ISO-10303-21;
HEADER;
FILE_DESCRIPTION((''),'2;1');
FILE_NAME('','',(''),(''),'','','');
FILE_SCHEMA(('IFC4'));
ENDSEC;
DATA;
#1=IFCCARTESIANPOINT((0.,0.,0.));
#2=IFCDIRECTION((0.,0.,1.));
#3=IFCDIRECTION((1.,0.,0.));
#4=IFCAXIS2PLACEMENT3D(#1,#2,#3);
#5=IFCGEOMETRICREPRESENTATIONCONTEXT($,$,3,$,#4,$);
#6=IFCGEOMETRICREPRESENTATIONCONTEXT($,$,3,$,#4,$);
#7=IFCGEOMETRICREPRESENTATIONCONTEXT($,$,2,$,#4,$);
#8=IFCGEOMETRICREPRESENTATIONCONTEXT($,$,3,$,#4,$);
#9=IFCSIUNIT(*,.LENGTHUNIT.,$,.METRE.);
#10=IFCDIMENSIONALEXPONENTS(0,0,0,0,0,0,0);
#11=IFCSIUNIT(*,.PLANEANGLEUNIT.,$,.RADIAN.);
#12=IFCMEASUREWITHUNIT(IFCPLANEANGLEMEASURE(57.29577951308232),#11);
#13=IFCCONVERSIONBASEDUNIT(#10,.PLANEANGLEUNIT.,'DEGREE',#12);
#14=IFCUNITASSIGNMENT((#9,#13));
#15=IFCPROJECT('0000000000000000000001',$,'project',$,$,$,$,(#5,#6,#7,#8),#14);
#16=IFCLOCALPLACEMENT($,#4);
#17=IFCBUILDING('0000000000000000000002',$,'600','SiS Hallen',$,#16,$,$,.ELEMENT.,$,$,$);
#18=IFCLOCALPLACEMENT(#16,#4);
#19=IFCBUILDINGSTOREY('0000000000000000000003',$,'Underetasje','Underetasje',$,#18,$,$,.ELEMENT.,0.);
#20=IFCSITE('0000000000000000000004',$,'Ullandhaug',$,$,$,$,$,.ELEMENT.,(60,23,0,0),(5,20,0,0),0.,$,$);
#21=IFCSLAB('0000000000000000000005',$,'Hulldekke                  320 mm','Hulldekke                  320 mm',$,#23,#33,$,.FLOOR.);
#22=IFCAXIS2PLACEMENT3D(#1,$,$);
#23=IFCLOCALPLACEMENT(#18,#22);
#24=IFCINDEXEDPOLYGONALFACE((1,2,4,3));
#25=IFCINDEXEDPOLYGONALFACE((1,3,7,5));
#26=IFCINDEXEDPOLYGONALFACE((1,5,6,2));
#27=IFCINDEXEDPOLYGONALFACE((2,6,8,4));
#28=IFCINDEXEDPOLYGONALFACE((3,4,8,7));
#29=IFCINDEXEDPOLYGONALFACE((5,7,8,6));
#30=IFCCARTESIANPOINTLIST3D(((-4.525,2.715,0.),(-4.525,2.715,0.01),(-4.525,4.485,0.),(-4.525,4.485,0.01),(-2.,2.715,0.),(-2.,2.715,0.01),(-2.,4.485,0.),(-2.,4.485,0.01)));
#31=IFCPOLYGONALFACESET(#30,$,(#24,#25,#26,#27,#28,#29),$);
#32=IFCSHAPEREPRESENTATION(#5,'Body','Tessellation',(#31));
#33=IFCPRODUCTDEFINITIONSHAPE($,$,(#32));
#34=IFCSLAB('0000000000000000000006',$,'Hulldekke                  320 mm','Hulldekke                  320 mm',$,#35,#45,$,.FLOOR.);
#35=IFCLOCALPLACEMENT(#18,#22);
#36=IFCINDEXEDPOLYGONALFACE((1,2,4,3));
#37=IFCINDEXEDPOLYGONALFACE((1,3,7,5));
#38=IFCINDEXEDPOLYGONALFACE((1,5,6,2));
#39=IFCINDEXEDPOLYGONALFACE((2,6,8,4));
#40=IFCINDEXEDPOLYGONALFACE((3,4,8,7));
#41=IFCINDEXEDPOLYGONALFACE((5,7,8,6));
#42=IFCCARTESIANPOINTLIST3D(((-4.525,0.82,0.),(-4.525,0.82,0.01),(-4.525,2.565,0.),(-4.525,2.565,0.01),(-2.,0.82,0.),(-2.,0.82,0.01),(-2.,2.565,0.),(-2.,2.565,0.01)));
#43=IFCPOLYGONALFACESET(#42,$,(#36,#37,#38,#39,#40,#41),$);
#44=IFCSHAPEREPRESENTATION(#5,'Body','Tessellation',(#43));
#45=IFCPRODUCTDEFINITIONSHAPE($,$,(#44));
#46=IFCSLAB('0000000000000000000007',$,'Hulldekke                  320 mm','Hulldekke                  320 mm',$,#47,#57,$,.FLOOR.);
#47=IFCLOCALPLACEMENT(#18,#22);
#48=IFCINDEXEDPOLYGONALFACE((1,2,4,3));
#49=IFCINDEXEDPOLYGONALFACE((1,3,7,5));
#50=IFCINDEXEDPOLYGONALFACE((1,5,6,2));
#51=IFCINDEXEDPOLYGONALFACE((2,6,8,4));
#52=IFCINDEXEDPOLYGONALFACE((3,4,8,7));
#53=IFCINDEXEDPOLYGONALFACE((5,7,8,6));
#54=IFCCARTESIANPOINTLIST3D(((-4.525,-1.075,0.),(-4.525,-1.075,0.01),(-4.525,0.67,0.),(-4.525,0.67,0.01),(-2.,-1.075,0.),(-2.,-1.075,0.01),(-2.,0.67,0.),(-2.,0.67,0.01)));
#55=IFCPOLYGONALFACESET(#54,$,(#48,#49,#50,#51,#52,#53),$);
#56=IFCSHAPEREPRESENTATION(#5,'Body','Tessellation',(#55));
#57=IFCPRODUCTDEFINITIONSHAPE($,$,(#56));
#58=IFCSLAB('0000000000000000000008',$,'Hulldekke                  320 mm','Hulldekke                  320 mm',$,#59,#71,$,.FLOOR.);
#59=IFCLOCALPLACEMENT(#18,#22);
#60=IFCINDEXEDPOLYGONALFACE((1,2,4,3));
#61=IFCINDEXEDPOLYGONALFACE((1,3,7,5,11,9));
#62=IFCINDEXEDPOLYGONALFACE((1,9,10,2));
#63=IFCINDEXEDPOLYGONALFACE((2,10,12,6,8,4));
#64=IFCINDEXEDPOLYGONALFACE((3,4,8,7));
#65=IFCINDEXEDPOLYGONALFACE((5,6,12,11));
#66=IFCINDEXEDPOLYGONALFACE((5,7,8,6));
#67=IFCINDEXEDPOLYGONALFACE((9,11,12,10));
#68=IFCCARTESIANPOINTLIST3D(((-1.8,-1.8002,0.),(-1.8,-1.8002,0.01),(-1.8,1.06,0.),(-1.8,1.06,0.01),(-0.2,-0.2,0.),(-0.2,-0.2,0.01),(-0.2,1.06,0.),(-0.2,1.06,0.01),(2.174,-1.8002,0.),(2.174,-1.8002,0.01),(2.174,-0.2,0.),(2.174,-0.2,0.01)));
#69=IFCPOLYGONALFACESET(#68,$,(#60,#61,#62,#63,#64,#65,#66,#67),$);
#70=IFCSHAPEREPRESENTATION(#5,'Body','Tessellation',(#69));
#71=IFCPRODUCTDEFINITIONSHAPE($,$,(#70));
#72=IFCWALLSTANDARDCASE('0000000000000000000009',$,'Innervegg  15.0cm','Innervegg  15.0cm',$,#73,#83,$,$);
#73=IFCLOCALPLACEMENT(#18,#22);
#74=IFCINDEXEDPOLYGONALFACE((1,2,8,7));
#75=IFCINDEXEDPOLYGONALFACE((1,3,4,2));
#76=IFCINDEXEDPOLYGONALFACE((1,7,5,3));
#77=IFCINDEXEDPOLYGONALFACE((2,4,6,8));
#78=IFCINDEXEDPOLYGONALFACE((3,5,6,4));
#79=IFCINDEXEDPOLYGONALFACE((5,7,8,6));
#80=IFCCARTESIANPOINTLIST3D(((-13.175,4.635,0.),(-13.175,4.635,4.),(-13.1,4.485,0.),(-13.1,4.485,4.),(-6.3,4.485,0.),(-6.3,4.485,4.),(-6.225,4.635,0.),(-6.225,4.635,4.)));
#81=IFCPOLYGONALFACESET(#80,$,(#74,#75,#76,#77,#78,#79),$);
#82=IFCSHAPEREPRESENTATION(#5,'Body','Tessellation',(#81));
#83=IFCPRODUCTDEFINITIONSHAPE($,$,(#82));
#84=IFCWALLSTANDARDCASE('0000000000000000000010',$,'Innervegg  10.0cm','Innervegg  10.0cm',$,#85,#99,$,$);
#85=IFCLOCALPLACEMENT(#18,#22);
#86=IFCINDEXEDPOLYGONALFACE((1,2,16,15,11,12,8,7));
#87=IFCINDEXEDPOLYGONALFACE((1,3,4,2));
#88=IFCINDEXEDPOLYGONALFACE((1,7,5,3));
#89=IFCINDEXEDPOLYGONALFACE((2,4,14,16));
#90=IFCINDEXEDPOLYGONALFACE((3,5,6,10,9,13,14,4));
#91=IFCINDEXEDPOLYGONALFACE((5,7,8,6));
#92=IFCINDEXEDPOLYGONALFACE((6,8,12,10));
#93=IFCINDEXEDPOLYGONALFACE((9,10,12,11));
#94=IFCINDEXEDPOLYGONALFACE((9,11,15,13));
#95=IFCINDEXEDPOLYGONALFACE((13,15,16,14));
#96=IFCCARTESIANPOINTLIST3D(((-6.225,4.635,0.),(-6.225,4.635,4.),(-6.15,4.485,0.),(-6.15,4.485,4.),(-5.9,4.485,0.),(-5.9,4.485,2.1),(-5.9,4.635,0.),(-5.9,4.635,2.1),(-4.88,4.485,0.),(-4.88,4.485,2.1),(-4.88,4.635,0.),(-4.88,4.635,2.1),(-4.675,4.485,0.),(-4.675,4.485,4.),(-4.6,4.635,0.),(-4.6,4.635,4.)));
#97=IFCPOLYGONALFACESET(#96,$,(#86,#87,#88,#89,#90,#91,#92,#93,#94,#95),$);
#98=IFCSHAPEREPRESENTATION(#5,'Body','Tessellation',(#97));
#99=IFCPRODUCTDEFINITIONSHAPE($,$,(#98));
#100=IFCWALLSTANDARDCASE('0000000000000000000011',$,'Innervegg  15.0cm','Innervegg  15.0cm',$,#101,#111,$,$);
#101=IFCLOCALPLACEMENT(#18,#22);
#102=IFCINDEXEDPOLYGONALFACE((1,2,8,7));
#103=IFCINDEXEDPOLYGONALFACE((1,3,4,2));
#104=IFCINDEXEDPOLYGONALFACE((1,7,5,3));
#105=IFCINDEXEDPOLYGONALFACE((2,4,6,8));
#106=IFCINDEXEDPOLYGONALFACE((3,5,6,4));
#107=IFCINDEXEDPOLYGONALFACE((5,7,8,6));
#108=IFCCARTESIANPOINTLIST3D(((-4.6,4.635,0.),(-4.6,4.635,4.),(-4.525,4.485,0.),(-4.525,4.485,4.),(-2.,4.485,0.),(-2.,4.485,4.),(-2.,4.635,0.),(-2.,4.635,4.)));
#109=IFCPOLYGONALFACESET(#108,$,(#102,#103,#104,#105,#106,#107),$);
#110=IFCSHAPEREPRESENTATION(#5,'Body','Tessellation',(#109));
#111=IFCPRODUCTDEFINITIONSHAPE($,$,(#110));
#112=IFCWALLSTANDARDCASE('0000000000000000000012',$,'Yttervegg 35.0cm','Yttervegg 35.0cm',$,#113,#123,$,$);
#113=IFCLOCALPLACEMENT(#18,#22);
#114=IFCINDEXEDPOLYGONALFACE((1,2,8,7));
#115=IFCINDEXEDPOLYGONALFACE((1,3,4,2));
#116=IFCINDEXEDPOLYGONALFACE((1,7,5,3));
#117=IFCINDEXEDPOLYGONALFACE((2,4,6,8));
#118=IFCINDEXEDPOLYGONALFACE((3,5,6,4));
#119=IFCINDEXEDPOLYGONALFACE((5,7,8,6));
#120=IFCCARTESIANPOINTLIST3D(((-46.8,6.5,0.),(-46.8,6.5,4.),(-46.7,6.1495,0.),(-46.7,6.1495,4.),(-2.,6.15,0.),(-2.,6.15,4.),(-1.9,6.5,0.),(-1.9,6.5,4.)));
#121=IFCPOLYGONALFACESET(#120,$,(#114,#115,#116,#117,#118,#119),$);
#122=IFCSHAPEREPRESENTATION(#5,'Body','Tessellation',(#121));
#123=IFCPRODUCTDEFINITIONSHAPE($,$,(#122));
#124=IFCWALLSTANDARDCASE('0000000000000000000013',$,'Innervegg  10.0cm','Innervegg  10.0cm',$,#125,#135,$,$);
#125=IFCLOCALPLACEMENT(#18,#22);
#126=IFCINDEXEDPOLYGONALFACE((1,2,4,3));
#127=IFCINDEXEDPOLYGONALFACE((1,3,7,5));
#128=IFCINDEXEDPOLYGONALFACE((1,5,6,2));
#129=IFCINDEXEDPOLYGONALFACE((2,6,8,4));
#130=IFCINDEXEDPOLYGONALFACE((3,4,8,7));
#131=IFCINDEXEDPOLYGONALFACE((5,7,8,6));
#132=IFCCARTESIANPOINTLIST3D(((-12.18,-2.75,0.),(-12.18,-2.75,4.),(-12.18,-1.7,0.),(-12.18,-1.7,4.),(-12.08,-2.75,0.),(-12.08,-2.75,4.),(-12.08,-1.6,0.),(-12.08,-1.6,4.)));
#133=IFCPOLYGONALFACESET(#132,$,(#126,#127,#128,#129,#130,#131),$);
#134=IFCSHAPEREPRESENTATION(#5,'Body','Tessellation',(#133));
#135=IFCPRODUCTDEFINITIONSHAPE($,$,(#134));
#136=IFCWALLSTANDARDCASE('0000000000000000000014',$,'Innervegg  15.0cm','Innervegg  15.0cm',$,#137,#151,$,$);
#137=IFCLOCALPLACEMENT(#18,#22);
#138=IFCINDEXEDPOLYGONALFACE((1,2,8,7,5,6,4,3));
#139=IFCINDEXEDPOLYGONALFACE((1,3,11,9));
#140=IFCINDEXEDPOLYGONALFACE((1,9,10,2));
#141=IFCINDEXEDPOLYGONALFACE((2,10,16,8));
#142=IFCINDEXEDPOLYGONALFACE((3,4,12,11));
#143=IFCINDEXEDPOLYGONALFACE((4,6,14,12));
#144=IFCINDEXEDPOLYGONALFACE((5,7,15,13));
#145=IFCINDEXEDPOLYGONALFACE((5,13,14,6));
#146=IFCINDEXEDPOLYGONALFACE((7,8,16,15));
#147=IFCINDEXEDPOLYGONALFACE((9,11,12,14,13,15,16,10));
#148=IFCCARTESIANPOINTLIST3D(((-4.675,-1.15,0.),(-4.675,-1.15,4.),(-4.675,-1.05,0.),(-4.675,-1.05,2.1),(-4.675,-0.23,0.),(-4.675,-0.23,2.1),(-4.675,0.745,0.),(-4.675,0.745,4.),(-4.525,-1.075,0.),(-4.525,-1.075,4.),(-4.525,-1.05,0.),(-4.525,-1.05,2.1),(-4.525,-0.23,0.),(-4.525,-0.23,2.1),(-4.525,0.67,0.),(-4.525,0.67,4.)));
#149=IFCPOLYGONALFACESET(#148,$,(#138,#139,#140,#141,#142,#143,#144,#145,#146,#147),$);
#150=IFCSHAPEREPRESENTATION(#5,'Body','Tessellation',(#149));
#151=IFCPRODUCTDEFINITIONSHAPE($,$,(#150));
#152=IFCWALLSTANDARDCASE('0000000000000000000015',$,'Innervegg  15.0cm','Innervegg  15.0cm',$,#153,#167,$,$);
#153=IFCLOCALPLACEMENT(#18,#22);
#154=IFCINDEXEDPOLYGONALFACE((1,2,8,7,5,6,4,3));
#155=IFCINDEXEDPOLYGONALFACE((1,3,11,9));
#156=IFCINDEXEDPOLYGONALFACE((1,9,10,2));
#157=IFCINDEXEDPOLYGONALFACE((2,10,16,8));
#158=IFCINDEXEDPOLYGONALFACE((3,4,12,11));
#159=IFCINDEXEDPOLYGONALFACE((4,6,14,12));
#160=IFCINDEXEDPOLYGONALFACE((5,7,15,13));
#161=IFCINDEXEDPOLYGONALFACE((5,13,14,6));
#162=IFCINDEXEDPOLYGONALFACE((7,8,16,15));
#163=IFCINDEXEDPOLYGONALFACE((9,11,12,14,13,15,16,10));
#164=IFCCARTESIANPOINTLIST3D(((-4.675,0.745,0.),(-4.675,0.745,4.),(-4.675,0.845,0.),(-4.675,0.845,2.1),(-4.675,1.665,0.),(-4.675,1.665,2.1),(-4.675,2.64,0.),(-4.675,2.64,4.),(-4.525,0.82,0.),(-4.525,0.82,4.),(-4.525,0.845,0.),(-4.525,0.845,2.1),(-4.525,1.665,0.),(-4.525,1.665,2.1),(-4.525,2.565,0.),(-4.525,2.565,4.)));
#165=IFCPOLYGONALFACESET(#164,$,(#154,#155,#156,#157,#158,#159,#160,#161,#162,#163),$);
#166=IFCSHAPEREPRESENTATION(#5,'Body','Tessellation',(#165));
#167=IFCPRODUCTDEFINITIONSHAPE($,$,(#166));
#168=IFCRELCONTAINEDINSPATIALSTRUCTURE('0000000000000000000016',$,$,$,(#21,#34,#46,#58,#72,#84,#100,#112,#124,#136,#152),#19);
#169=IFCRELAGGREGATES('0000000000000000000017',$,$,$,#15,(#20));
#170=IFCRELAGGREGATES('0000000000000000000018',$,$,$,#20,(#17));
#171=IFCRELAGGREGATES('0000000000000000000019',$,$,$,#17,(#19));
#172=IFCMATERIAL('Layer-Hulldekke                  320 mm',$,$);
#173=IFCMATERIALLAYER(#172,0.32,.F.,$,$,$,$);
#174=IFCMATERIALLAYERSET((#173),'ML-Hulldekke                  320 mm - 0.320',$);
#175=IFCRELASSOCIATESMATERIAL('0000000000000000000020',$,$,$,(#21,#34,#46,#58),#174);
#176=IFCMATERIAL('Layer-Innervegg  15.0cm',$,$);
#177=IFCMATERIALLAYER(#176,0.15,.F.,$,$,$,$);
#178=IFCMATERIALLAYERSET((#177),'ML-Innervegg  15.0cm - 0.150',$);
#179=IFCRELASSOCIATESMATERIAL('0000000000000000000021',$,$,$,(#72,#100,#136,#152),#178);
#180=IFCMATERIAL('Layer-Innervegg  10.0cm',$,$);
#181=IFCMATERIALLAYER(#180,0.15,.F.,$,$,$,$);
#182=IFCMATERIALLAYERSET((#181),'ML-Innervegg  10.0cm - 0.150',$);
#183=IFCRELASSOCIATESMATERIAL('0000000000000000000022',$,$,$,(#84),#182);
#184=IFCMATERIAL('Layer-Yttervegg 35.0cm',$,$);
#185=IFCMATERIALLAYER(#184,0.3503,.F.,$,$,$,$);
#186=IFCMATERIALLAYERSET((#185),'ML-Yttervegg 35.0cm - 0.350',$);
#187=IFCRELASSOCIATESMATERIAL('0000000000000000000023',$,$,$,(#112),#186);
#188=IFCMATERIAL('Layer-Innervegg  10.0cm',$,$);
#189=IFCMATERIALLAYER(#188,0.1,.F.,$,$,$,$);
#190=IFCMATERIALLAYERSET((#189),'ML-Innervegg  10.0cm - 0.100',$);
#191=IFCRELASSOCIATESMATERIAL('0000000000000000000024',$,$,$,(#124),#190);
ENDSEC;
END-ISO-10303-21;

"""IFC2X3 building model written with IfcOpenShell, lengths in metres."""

from ifc_helpers import new_model, entity, si_unit, converted_unit, frame, origin_with_axes, place, context, project, spatial, polyline, outline, extrude, material, layer, layer_set, layer_usage, element, save


model = new_model("IFC2X3")

# Units and contexts
context_of_model_1 = context(None, 3, world=origin_with_axes())
context_of_model_2 = context(None, 3, world=origin_with_axes())
context_of_model_3 = context(None, 2, world=origin_with_axes())
context_of_model_4 = context(None, 3, world=origin_with_axes())
ifc_project = project(units=[si_unit("LENGTHUNIT", "METRE"), converted_unit("PLANEANGLEUNIT", "DEGREE", entity("IfcPlaneAngleMeasure", 57.29577951308232), si_unit("PLANEANGLEUNIT", "RADIAN"), dimensions=[0, 0, 0, 0, 0, 0, 0])], contexts=[context_of_model_1, context_of_model_2, context_of_model_3, context_of_model_4])

# Site, building, storey
site = spatial("IfcSite", under=ifc_project, Name="Ullandhaug", CompositionType="ELEMENT", RefLatitude=(60, 23, 0, 0), RefLongitude=(5, 20, 0, 0), RefElevation=0.0)
building_placement = place(None, origin_with_axes())
building = spatial("IfcBuilding", under=site, at=building_placement, Name="600", Description="SiS Hallen", CompositionType="ELEMENT")
storey_placement = place(building_placement, origin_with_axes())
storey = spatial("IfcBuildingStorey", under=building, at=storey_placement, Name="Underetasje", Description="Underetasje", CompositionType="ELEMENT", Elevation=0.0)

# Slabs
ifc_material_1 = material(Name="Layer-Hulldekke                  320 mm")
ifc_layer_1 = layer(ifc_material_1, 0.32, ventilated=False)
ifc_layer_set_1 = layer_set([ifc_layer_1], Name="ML-Hulldekke                  320 mm - 0.320")
ifc_layer_usage_1 = layer_usage(ifc_layer_set_1, "AXIS2", "POSITIVE", 0.0)
slab_1_placement = place(storey_placement, frame((-4.525, 2.715, 0.0), z_axis=(0.0, 0.0, 1.0), x_axis=(1.0, 0.0, 0.0)))
element("IfcSlab", 1, at=slab_1_placement, inside=storey, material=ifc_layer_usage_1, Name="Hulldekke                  320 mm", Description="Hulldekke                  320 mm", PredefinedType="FLOOR", context=context_of_model_1, shape_type="SweptSolid", body=[
    extrude(outline(polyline([(0.0, 0.0), (2.525, 0.0), (2.525, 1.77), (0.0, 1.77), (0.0, 0.0)])), origin_with_axes(), (0.0, 0.0, 1.0), 0.01),
])
slab_2_placement = place(storey_placement, frame((-4.525, 0.82, 0.0), z_axis=(0.0, 0.0, 1.0), x_axis=(1.0, 0.0, 0.0)))
element("IfcSlab", 2, at=slab_2_placement, inside=storey, material=ifc_layer_usage_1, Name="Hulldekke                  320 mm", Description="Hulldekke                  320 mm", PredefinedType="FLOOR", context=context_of_model_1, shape_type="SweptSolid", body=[
    extrude(outline(polyline([(0.0, 0.0), (2.525, 0.0), (2.525, 1.745), (0.0, 1.745), (0.0, 0.0)])), origin_with_axes(), (0.0, 0.0, 1.0), 0.01),
])
slab_3_placement = place(storey_placement, frame((-4.525, -1.075, 0.0), z_axis=(0.0, 0.0, 1.0), x_axis=(1.0, 0.0, 0.0)))
element("IfcSlab", 3, at=slab_3_placement, inside=storey, material=ifc_layer_usage_1, Name="Hulldekke                  320 mm", Description="Hulldekke                  320 mm", PredefinedType="FLOOR", context=context_of_model_1, shape_type="SweptSolid", body=[
    extrude(outline(polyline([(0.0, 0.0), (2.525, 0.0), (2.525, 1.745), (0.0, 1.745), (0.0, 0.0)])), origin_with_axes(), (0.0, 0.0, 1.0), 0.01),
])
slab_4_placement = place(storey_placement, frame((-1.8, -1.8002, 0.0), z_axis=(0.0, 0.0, 1.0), x_axis=(1.0, 0.0, 0.0)))
element("IfcSlab", 4, at=slab_4_placement, inside=storey, material=ifc_layer_usage_1, Name="Hulldekke                  320 mm", Description="Hulldekke                  320 mm", PredefinedType="FLOOR", context=context_of_model_1, shape_type="SweptSolid", body=[
    extrude(outline(polyline([(0.0, 0.0), (3.974, 0.0), (3.974, 1.6002), (1.6, 1.6002), (1.6, 2.8602), (0.0, 2.8602), (0.0, 0.0)])), origin_with_axes(), (0.0, 0.0, 1.0), 0.01),
])

# Wall
ifc_material_2 = material(Name="Layer-Innervegg  15.0cm")
ifc_layer_2 = layer(ifc_material_2, 0.15, ventilated=False)
ifc_layer_set_2 = layer_set([ifc_layer_2], Name="ML-Innervegg  15.0cm - 0.150")
ifc_layer_usage_2 = layer_usage(ifc_layer_set_2, "AXIS2", "POSITIVE", 0.0)
wall_1_placement = place(storey_placement, frame((-13.1, 4.485, 0.0), z_axis=(0.0, 0.0, 1.0), x_axis=(1.0, 0.0, 0.0)))
element("IfcWallStandardCase", 5, at=wall_1_placement, inside=storey, material=ifc_layer_usage_2, Name="Innervegg  15.0cm", Description="Innervegg  15.0cm", context=context_of_model_1, shape_type="SweptSolid", body=[
    extrude(outline(polyline([(0.0, 0.0), (6.8, 0.0), (6.875, 0.15), (-0.075, 0.15), (0.0, 0.0)])), origin_with_axes(), (0.0, 0.0, 1.0), 4.0),
])

# Wall, opening
ifc_material_3 = material(Name="Layer-Innervegg  10.0cm")
ifc_layer_3 = layer(ifc_material_3, 0.15, ventilated=False)
ifc_layer_set_3 = layer_set([ifc_layer_3], Name="ML-Innervegg  10.0cm - 0.150")
ifc_layer_usage_3 = layer_usage(ifc_layer_set_3, "AXIS2", "POSITIVE", 0.0)
wall_2_placement = place(storey_placement, frame((-6.15, 4.485, 0.0), z_axis=(0.0, 0.0, 1.0), x_axis=(1.0, 0.0, 0.0)))
wall_2 = element("IfcWallStandardCase", 6, at=wall_2_placement, inside=storey, material=ifc_layer_usage_3, Name="Innervegg  10.0cm", Description="Innervegg  10.0cm", context=context_of_model_1, shape_type="SweptSolid", body=[
    extrude(outline(polyline([(0.0, 0.0), (1.475, 0.0), (1.55, 0.15), (-0.075, 0.15), (0.0, 0.0)])), origin_with_axes(), (0.0, 0.0, 1.0), 4.0),
])
opening_1_placement = place(wall_2_placement, frame((0.25, 0.15, 0.0), z_axis=(0.0, 0.0, 1.0), x_axis=(1.0, 0.0, 0.0)))
element("IfcOpeningElement", 7, at=opening_1_placement, cuts=wall_2, context=context_of_model_1, shape_type="SweptSolid", body=[
    extrude(outline(polyline([(0.0, 0.0), (2.1, 0.0), (2.1, 1.02), (0.0, 1.02), (0.0, 0.0)])), frame((0.0, 0.0, 0.0), z_axis=(0.0, 1.0, 0.0), x_axis=(0.0, 0.0, 1.0)), (0.0, 0.0, -1.0), 0.15),
])

# Walls
wall_3_placement = place(storey_placement, frame((-4.525, 4.485, 0.0), z_axis=(0.0, 0.0, 1.0), x_axis=(1.0, 0.0, 0.0)))
element("IfcWallStandardCase", 8, at=wall_3_placement, inside=storey, material=ifc_layer_usage_2, Name="Innervegg  15.0cm", Description="Innervegg  15.0cm", context=context_of_model_1, shape_type="SweptSolid", body=[
    extrude(outline(polyline([(0.0, 0.0), (2.525, 0.0), (2.525, 0.15), (-0.075, 0.15), (0.0, 0.0)])), origin_with_axes(), (0.0, 0.0, 1.0), 4.0),
])
ifc_material_4 = material(Name="Layer-Yttervegg 35.0cm")
ifc_layer_4 = layer(ifc_material_4, 0.3503, ventilated=False)
ifc_layer_set_4 = layer_set([ifc_layer_4], Name="ML-Yttervegg 35.0cm - 0.350")
ifc_layer_usage_4 = layer_usage(ifc_layer_set_4, "AXIS2", "POSITIVE", 0.0)
wall_4_placement = place(storey_placement, frame((-1.9, 6.5, 0.0), z_axis=(0.0, 0.0, 1.0), x_axis=(-1.0, 0.0, 0.0)))
element("IfcWallStandardCase", 9, at=wall_4_placement, inside=storey, material=ifc_layer_usage_4, Name="Yttervegg 35.0cm", Description="Yttervegg 35.0cm", context=context_of_model_1, shape_type="SweptSolid", body=[
    extrude(outline(polyline([(0.0, 0.0), (44.9, 0.0), (44.8, 0.3505), (0.1, 0.35), (0.0, 0.0)])), frame((0.0, 0.0, 0.0), z_axis=(0.0, 0.0, 1.0), x_axis=(1.0, 0.0, 0.0)), (0.0, 0.0, 1.0), 4.0),
])
ifc_material_5 = material(Name="Layer-Innervegg  10.0cm")
ifc_layer_5 = layer(ifc_material_5, 0.1, ventilated=False)
ifc_layer_set_5 = layer_set([ifc_layer_5], Name="ML-Innervegg  10.0cm - 0.100")
ifc_layer_usage_5 = layer_usage(ifc_layer_set_5, "AXIS2", "POSITIVE", 0.0)
wall_5_placement = place(storey_placement, frame((-12.18, -1.7, 0.0), z_axis=(0.0, 0.0, 1.0), x_axis=(0.0, -1.0, 0.0)))
element("IfcWallStandardCase", 10, at=wall_5_placement, inside=storey, material=ifc_layer_usage_5, Name="Innervegg  10.0cm", Description="Innervegg  10.0cm", context=context_of_model_1, shape_type="SweptSolid", body=[
    extrude(outline(polyline([(0.0, 0.0), (1.05, 0.0), (1.05, 0.1), (-0.1, 0.1), (0.0, 0.0)])), frame((0.0, 0.0, 0.0), z_axis=(0.0, 0.0, 1.0), x_axis=(1.0, 0.0, 0.0)), (0.0, 0.0, 1.0), 4.0),
])

# Walls, openings
wall_6_placement = place(storey_placement, frame((-4.525, -1.075, 0.0), z_axis=(0.0, 0.0, 1.0), x_axis=(0.0, 1.0, 0.0)))
wall_6 = element("IfcWallStandardCase", 11, at=wall_6_placement, inside=storey, material=ifc_layer_usage_2, Name="Innervegg  15.0cm", Description="Innervegg  15.0cm", context=context_of_model_1, shape_type="SweptSolid", body=[
    extrude(outline(polyline([(0.0, 0.0), (1.745, 0.0), (1.82, 0.15), (-0.075, 0.15), (0.0, 0.0)])), frame((0.0, 0.0, 0.0), z_axis=(0.0, 0.0, 1.0), x_axis=(1.0, 0.0, 0.0)), (0.0, 0.0, 1.0), 4.0),
])
opening_2_placement = place(wall_6_placement, frame((0.025, 0.15, 0.0), z_axis=(0.0, 0.0, 1.0), x_axis=(1.0, 0.0, 0.0)))
element("IfcOpeningElement", 12, at=opening_2_placement, cuts=wall_6, context=context_of_model_1, shape_type="SweptSolid", body=[
    extrude(outline(polyline([(0.0, 0.0), (2.1, 0.0), (2.1, 0.82), (0.0, 0.82), (0.0, 0.0)])), frame((0.0, 0.0, 0.0), z_axis=(0.0, 1.0, 0.0), x_axis=(0.0, 0.0, 1.0)), (0.0, 0.0, -1.0), 0.15),
])
wall_7_placement = place(storey_placement, frame((-4.525, 0.82, 0.0), z_axis=(0.0, 0.0, 1.0), x_axis=(0.0, 1.0, 0.0)))
wall_7 = element("IfcWallStandardCase", 13, at=wall_7_placement, inside=storey, material=ifc_layer_usage_2, Name="Innervegg  15.0cm", Description="Innervegg  15.0cm", context=context_of_model_1, shape_type="SweptSolid", body=[
    extrude(outline(polyline([(0.0, 0.0), (1.745, 0.0), (1.82, 0.15), (-0.075, 0.15), (0.0, 0.0)])), frame((0.0, 0.0, 0.0), z_axis=(0.0, 0.0, 1.0), x_axis=(1.0, 0.0, 0.0)), (0.0, 0.0, 1.0), 4.0),
])
opening_3_placement = place(wall_7_placement, frame((0.025, 0.15, 0.0), z_axis=(0.0, 0.0, 1.0), x_axis=(1.0, 0.0, 0.0)))
element("IfcOpeningElement", 14, at=opening_3_placement, cuts=wall_7, context=context_of_model_1, shape_type="SweptSolid", body=[
    extrude(outline(polyline([(0.0, 0.0), (2.1, 0.0), (2.1, 0.82), (0.0, 0.82), (0.0, 0.0)])), frame((0.0, 0.0, 0.0), z_axis=(0.0, 1.0, 0.0), x_axis=(0.0, 0.0, 1.0)), (0.0, 0.0, -1.0), 0.15),
])

save(model, "model.ifc")
